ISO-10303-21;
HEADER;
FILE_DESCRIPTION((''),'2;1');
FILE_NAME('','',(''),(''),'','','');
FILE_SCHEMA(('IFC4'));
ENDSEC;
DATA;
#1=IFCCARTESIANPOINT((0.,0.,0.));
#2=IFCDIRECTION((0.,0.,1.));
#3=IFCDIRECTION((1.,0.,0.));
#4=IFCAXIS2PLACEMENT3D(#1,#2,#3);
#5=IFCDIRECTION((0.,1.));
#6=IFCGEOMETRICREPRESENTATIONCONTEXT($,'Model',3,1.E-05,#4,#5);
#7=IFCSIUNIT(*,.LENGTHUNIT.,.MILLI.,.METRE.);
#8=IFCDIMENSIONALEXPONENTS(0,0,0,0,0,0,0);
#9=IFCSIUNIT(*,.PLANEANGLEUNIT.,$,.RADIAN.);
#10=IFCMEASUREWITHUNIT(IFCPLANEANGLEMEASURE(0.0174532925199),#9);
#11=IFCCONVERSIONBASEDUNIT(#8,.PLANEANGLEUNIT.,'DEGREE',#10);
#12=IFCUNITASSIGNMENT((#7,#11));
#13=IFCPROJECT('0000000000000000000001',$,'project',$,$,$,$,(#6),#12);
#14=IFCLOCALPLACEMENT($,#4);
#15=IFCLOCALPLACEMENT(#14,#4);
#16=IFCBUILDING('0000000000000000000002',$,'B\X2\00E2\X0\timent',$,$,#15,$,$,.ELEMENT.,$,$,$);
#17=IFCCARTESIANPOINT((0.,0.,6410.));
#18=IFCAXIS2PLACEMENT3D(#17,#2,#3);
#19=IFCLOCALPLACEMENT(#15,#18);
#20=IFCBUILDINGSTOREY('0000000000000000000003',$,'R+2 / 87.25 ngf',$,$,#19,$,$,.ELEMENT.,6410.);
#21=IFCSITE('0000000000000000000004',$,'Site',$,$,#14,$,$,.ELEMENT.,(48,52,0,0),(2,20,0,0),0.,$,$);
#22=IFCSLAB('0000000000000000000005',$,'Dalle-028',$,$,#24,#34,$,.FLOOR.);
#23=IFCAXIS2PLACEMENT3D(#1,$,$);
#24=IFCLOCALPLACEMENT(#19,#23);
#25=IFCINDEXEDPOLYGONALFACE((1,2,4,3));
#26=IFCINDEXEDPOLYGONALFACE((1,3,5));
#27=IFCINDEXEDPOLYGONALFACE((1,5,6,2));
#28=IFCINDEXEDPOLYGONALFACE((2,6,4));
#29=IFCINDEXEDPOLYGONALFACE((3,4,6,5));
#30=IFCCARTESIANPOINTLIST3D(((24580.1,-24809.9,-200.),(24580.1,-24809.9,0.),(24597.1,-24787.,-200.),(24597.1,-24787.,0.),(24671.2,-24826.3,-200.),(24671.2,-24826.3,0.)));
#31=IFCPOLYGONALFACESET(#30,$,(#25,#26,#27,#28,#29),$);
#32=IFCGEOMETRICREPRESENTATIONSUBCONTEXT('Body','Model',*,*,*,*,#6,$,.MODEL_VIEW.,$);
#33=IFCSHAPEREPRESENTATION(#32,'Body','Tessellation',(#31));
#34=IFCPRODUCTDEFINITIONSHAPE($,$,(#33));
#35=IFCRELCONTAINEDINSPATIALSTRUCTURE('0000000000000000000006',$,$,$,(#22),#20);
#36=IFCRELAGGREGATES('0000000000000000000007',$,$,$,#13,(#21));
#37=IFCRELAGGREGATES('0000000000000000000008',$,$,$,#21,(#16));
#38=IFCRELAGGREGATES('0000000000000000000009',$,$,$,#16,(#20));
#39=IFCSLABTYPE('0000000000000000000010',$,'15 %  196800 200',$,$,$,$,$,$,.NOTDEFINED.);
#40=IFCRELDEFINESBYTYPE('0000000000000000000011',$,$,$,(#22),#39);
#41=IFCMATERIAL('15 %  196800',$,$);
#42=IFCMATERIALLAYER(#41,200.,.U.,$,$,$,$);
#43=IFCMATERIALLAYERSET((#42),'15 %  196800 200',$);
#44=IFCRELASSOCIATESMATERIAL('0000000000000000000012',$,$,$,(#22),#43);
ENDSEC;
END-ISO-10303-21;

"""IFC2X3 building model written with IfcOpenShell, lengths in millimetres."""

from ifc_helpers import new_model, entity, si_unit, converted_unit, direction, frame, origin_with_axes, place, context, subcontext, project, spatial, polyline, outline, extrude, material, layer, layer_set, layer_usage, type_object, element, save


model = new_model("IFC2X3")

# Units and contexts
model_context = context("Model", 3, precision=1e-05, world=origin_with_axes(), true_north=direction((0.0, 1.0)))
body_context = subcontext(model_context, "Body", "Model", "MODEL_VIEW")
ifc_project = project(units=[si_unit("LENGTHUNIT", "METRE", prefix="MILLI"), converted_unit("PLANEANGLEUNIT", "DEGREE", entity("IfcPlaneAngleMeasure", 0.0174532925199), si_unit("PLANEANGLEUNIT", "RADIAN"), dimensions=[0, 0, 0, 0, 0, 0, 0])], contexts=[model_context])

# Site, building, storey
site_placement = place(None, origin_with_axes())
site = spatial("IfcSite", under=ifc_project, at=site_placement, Name="Site", CompositionType="ELEMENT", RefLatitude=(48, 52, 0, 0), RefLongitude=(2, 20, 0, 0), RefElevation=0.0)
building_placement = place(site_placement, origin_with_axes())
building = spatial("IfcBuilding", under=site, at=building_placement, Name="Bâtiment", CompositionType="ELEMENT")
storey_placement = place(building_placement, frame((0.0, 0.0, 6410.0), z_axis=(0.0, 0.0, 1.0), x_axis=(1.0, 0.0, 0.0)))
storey = spatial("IfcBuildingStorey", under=building, at=storey_placement, Name="R+2 / 87.25 ngf", CompositionType="ELEMENT", Elevation=6410.0)

# Slab
ifc_material_1 = material(Name="15 %  196800")
ifc_layer_1 = layer(ifc_material_1, 200.0, ventilated="UNKNOWN")
ifc_layer_set_1 = layer_set([ifc_layer_1], Name="15 %  196800 200")
slab_type = type_object("IfcSlabType", Name="15 %  196800 200", PredefinedType="NOTDEFINED")
ifc_layer_usage_1 = layer_usage(ifc_layer_set_1, "AXIS3", "NEGATIVE", 200.0)
slab_1_placement = place(storey_placement, frame((24597.1, -24787.0, 0.0), z_axis=(0.0, 0.0, 1.0), x_axis=(1.0, 0.0, 0.0)))
element("IfcSlab", 1, at=slab_1_placement, inside=storey, type_object=slab_type, material=ifc_layer_usage_1, Name="Dalle-028", PredefinedType="FLOOR", context=body_context, shape_type="SweptSolid", body=[
    extrude(outline(polyline([(0.0, 0.0), (-17.0, -23.0), (74.1, -39.4), (0.0, 0.0)])), frame((0.0, 0.0, -200.0), z_axis=(0.0, 0.0, 1.0), x_axis=(1.0, 0.0, 0.0)), (0.0, 0.0, 1.0), 200.0),
])

save(model, "model.ifc")
